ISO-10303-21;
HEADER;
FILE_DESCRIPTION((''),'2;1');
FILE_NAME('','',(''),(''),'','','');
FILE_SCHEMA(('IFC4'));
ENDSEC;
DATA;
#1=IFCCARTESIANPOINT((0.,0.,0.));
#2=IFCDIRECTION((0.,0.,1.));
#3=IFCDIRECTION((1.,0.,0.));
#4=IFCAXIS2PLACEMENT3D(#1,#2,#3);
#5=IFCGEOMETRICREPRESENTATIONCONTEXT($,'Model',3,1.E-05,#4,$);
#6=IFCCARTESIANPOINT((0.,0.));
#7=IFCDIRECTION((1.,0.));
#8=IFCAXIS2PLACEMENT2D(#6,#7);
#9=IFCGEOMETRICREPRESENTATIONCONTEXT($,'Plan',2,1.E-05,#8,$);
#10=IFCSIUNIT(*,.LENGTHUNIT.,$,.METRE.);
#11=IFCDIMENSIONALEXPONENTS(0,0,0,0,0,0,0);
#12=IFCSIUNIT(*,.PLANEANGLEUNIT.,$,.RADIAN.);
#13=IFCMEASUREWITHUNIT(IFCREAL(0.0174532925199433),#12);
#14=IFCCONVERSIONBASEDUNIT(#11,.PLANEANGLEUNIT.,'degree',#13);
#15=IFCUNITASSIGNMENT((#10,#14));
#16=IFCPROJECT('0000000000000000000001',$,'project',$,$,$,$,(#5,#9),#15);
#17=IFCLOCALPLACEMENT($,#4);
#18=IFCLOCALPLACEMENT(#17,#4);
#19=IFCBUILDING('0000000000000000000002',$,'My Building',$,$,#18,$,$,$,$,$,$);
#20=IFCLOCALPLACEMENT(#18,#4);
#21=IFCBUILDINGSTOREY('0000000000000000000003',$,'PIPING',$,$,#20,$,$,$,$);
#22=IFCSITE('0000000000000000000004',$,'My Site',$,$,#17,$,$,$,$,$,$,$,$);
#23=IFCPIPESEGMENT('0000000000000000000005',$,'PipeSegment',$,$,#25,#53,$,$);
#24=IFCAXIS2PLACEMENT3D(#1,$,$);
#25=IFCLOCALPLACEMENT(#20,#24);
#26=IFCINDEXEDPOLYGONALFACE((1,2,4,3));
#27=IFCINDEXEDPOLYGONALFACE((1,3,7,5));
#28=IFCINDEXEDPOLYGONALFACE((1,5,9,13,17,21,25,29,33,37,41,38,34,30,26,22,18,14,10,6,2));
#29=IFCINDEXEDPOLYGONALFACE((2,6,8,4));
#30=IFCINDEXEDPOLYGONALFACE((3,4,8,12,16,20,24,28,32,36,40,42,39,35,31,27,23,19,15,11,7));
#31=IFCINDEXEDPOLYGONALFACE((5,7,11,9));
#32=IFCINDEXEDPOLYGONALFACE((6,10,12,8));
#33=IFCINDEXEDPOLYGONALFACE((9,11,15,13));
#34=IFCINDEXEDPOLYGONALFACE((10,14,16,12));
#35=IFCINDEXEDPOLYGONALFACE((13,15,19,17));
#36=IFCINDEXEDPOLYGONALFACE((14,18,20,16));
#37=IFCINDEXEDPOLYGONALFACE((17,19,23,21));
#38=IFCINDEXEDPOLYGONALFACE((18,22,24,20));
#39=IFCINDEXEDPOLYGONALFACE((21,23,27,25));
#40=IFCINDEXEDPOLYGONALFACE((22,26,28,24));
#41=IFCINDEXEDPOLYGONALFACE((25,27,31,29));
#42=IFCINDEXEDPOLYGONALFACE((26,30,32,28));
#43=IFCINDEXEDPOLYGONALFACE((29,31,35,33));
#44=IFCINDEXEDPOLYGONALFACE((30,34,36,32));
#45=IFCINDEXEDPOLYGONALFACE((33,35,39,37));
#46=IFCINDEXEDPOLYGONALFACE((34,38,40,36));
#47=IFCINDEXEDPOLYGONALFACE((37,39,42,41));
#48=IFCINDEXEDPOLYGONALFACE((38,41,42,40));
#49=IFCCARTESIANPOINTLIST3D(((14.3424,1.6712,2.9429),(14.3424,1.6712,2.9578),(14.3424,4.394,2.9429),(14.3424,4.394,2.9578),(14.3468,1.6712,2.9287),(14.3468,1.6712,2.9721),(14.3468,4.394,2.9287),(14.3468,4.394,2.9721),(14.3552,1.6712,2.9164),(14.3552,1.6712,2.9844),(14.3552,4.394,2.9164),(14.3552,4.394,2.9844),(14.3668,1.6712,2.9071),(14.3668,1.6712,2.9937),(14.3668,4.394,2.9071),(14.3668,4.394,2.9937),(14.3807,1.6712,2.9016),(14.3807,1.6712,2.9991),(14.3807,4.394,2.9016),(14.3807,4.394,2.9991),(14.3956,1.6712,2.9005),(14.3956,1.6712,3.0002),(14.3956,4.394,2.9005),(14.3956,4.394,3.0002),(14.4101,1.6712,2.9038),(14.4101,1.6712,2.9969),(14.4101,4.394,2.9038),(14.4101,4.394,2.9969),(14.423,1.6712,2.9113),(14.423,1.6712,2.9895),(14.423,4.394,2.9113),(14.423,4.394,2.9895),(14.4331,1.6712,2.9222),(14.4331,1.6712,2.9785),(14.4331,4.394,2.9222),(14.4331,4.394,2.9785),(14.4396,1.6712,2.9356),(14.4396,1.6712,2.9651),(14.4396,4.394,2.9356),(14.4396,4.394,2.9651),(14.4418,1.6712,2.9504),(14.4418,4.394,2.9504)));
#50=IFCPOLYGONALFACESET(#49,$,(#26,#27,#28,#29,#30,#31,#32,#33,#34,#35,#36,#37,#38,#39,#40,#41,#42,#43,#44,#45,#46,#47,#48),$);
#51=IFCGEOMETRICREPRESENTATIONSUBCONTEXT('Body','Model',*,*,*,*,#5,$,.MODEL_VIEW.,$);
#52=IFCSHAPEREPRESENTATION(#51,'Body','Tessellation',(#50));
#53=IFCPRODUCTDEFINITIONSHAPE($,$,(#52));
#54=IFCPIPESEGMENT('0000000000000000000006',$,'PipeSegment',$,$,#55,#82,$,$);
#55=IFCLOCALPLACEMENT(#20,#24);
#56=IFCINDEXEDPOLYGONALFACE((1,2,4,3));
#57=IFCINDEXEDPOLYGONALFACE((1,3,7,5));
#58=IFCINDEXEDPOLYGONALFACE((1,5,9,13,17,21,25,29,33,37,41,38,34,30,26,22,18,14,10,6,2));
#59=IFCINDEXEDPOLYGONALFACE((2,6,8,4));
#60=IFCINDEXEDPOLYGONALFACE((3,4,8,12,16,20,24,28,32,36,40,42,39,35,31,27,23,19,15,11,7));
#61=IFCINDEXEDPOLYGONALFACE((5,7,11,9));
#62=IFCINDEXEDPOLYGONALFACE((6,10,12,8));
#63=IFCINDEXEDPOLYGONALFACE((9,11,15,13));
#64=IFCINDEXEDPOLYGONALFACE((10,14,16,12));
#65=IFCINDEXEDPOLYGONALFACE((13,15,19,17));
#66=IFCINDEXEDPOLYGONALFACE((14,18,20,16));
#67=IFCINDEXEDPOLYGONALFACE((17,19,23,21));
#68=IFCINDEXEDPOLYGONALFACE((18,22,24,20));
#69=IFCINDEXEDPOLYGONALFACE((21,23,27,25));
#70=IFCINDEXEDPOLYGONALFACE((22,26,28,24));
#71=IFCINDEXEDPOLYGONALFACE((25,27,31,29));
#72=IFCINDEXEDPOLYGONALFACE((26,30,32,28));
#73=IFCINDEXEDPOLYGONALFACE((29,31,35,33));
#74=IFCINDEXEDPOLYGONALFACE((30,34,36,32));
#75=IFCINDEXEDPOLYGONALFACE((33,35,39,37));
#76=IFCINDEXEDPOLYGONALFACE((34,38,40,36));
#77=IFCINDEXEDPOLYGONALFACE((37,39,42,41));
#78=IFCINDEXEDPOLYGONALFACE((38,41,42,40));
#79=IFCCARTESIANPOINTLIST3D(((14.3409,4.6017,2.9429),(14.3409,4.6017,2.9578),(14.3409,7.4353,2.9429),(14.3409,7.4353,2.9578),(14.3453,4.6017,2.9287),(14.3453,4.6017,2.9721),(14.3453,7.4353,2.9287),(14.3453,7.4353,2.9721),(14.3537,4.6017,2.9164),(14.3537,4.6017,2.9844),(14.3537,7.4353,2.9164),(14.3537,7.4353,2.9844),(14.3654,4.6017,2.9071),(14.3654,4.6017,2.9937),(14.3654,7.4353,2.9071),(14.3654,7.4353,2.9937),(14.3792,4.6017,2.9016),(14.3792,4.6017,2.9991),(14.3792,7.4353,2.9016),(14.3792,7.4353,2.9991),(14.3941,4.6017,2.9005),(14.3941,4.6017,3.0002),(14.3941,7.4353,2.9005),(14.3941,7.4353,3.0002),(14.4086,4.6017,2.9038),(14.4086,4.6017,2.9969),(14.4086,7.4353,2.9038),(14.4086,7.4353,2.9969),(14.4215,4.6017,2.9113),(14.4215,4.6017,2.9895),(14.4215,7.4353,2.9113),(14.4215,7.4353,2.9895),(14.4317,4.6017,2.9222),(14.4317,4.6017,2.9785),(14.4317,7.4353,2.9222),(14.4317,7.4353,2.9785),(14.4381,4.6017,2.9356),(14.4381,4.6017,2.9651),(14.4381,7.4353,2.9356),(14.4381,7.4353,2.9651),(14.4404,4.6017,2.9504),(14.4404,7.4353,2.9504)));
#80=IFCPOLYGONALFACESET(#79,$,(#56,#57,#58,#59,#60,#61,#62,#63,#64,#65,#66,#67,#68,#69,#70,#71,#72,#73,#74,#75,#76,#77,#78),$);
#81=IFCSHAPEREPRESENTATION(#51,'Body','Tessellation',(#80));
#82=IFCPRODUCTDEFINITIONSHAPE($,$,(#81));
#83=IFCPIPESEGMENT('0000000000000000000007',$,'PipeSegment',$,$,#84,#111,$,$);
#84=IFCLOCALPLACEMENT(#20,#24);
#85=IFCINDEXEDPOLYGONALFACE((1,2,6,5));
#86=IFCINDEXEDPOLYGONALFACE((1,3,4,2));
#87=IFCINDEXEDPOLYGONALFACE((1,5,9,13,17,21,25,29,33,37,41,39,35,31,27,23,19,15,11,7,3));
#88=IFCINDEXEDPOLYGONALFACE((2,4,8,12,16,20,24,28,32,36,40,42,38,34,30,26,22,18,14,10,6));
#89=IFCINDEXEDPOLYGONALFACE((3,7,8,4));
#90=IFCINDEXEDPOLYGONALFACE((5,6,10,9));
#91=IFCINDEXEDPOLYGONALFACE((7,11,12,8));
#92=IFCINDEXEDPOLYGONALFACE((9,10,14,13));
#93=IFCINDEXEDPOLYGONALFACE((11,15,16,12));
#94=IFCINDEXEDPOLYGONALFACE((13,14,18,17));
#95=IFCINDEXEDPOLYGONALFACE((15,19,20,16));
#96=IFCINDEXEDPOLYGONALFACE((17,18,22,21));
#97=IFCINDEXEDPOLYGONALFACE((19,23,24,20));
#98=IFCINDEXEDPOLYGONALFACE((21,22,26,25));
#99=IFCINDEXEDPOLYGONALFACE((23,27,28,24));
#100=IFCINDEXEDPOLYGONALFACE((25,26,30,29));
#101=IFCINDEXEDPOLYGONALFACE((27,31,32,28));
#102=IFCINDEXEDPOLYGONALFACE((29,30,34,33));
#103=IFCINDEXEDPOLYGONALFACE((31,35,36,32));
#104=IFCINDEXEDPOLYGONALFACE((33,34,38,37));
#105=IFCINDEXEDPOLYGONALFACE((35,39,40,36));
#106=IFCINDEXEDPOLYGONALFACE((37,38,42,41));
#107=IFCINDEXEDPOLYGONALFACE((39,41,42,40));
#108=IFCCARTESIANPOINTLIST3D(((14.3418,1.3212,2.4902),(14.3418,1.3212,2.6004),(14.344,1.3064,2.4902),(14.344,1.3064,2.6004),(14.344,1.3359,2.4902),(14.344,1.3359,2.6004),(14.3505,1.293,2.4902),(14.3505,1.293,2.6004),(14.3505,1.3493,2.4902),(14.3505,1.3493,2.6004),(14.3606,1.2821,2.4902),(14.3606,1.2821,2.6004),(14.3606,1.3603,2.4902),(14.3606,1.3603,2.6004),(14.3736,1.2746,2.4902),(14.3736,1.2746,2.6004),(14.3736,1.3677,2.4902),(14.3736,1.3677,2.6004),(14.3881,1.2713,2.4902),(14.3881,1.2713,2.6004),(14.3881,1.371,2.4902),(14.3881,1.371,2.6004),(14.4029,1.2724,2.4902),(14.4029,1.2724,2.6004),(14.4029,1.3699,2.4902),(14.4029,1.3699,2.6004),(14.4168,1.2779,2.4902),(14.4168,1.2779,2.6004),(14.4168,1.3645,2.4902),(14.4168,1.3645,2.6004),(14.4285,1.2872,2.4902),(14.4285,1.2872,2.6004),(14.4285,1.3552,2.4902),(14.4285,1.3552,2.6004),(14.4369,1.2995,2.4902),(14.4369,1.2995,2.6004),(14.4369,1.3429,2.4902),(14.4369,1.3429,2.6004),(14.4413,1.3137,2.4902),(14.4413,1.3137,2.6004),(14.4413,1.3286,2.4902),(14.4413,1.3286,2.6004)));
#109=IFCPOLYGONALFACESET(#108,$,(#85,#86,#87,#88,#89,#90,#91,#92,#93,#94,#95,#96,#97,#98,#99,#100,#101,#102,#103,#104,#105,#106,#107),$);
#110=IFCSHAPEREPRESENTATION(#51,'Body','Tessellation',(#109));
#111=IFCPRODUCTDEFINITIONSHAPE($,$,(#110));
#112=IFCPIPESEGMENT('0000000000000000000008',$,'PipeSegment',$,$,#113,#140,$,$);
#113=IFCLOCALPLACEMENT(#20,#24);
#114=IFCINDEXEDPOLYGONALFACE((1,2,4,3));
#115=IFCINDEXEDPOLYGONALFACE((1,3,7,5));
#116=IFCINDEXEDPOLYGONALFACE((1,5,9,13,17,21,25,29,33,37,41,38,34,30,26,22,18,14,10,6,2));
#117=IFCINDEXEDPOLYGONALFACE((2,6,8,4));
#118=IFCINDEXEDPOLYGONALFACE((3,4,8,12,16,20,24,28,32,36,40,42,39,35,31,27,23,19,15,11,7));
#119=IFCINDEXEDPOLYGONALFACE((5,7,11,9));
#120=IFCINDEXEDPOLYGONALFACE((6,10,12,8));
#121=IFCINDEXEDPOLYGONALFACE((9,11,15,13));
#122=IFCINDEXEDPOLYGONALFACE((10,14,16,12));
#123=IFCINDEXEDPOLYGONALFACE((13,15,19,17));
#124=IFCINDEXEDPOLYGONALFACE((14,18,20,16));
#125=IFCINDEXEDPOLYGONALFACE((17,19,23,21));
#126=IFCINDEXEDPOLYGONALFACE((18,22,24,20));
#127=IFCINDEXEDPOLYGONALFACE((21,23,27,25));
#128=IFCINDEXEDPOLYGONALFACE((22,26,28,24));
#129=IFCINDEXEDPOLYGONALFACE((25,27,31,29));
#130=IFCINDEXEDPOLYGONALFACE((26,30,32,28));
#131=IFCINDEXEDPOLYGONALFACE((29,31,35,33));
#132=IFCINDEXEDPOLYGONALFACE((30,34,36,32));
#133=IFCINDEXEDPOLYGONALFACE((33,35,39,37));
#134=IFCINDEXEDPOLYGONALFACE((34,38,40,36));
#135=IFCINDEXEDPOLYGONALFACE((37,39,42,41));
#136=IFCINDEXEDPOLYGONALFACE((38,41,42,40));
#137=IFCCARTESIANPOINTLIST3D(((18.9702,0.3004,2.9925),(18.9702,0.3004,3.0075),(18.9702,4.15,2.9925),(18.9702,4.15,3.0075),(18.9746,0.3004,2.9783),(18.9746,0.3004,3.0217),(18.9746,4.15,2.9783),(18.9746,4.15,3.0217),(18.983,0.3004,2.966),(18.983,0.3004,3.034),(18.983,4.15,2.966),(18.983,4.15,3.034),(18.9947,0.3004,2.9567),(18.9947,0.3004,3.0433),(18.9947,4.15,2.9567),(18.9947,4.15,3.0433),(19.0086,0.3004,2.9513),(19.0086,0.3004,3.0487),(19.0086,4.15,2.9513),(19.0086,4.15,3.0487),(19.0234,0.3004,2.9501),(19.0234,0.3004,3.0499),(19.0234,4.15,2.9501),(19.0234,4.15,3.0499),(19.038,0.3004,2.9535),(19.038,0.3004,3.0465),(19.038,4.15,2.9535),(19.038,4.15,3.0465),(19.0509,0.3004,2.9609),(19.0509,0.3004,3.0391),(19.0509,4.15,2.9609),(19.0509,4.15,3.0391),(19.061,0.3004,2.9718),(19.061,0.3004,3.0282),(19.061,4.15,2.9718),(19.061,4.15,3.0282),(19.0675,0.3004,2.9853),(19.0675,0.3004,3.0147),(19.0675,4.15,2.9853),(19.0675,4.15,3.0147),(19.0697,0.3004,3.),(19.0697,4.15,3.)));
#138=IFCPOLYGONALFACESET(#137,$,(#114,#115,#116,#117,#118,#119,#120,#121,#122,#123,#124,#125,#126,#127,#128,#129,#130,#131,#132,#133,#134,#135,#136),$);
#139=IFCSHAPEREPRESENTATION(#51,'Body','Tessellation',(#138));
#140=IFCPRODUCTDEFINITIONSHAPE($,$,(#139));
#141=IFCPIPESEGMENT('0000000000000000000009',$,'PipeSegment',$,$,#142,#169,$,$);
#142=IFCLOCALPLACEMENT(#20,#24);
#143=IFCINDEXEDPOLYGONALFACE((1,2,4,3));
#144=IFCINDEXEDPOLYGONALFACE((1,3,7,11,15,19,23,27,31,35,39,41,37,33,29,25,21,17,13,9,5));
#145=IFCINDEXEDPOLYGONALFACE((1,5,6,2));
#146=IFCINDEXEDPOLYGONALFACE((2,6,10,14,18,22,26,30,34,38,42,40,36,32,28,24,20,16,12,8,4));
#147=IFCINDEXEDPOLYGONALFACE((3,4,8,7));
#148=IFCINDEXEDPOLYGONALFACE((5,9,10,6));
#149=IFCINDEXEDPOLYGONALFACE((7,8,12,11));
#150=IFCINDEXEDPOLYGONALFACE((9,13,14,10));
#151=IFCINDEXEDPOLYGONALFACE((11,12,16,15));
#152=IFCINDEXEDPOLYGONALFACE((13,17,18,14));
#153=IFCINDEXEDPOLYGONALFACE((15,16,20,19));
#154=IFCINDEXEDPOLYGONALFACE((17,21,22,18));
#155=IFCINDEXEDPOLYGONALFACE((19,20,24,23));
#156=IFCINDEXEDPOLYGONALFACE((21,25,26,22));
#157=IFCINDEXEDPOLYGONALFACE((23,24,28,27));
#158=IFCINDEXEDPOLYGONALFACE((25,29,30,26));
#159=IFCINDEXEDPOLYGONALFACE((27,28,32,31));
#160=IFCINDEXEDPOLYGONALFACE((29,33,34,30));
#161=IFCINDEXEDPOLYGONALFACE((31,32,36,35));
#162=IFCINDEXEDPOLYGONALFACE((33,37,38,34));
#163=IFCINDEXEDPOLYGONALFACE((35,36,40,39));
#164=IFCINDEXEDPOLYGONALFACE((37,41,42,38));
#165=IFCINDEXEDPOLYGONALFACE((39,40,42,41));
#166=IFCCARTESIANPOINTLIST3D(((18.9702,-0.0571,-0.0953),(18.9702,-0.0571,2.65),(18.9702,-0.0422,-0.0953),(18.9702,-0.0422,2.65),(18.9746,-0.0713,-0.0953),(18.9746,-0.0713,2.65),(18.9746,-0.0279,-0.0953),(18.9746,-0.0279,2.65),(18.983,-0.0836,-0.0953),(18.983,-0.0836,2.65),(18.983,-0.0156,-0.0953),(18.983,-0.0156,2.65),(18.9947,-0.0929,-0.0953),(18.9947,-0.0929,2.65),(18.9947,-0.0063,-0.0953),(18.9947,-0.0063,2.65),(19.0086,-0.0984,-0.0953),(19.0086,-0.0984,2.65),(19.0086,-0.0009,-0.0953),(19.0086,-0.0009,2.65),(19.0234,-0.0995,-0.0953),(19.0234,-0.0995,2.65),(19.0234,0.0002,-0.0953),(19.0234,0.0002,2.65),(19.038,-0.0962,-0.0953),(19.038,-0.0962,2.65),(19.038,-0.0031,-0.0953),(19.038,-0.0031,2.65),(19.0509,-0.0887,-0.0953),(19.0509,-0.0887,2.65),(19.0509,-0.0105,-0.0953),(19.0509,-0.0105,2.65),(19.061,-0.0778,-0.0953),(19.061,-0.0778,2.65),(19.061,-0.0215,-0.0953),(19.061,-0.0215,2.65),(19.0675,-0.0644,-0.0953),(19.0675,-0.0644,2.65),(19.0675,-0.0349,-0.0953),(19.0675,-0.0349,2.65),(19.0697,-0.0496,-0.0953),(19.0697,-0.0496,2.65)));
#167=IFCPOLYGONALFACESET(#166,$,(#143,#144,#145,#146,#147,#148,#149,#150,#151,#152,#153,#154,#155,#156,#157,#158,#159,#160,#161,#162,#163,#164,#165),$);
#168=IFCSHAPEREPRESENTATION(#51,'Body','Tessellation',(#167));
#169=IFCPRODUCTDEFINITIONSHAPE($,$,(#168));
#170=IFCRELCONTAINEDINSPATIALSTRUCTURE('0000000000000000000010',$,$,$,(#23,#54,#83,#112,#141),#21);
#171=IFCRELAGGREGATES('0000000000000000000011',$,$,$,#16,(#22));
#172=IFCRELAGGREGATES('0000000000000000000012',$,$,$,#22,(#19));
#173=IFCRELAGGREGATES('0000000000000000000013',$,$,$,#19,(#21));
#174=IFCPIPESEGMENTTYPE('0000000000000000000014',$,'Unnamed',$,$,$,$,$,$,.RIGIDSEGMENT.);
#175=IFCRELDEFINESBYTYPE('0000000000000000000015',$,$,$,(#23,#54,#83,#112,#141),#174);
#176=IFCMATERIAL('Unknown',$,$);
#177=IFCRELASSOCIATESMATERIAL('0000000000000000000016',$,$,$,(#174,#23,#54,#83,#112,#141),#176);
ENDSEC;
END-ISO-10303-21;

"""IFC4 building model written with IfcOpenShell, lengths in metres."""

from ifc_helpers import new_model, entity, si_unit, converted_unit, frame, origin_with_axes, origin_2d_with_axis, place, context, subcontext, project, spatial, circle, extrude, material, material_profile, profile_set, profile_usage, type_object, element, save


model = new_model("IFC4")

# Units and contexts
model_context = context("Model", 3, precision=1e-05, world=origin_with_axes())
plan_context = context("Plan", 2, precision=1e-05, world=origin_2d_with_axis())
body_context = subcontext(model_context, "Body", "Model", "MODEL_VIEW")
ifc_project = project(units=[si_unit("LENGTHUNIT", "METRE"), converted_unit("PLANEANGLEUNIT", "degree", entity("IfcReal", 0.0174532925199433), si_unit("PLANEANGLEUNIT", "RADIAN"), dimensions=[0, 0, 0, 0, 0, 0, 0])], contexts=[model_context, plan_context])

# Site, building, storey
site_placement = place(None, origin_with_axes())
site = spatial("IfcSite", under=ifc_project, at=site_placement, Name="My Site")
building_placement = place(site_placement, origin_with_axes())
building = spatial("IfcBuilding", under=site, at=building_placement, Name="My Building")
storey_placement = place(building_placement, origin_with_axes())
storey = spatial("IfcBuildingStorey", under=building, at=storey_placement, Name="PIPING")

# Pipe segments
ifc_material = material(Name="Unknown")
ifc_material_profile_1 = material_profile(ifc_material, circle(Radius=0.05))
ifc_profile_set_1 = profile_set([ifc_material_profile_1])
pipe_segment_type = type_object("IfcPipeSegmentType", Name="Unnamed", PredefinedType="RIGIDSEGMENT", material=ifc_profile_set_1)
ifc_profile_usage_1 = profile_usage(ifc_profile_set_1, cardinal=5)
pipe_segment_1_placement = place(storey_placement, frame((14.3918, 1.6712, 2.9504), z_axis=(0.0, 1.0, 0.0), x_axis=(1.0, 0.0, 0.0)))
element("IfcPipeSegment", 1, at=pipe_segment_1_placement, inside=storey, type_object=pipe_segment_type, material=ifc_profile_usage_1, Name="PipeSegment", context=body_context, shape_type="SweptSolid", body=[
    extrude(circle(Radius=0.05), origin_with_axes(), (0.0, 0.0, 1.0), 2.7228),
])
ifc_profile_usage_2 = profile_usage(ifc_profile_set_1, cardinal=5)
pipe_segment_2_placement = place(storey_placement, frame((14.3904, 4.6017, 2.9504), z_axis=(0.0, 1.0, 0.0), x_axis=(1.0, 0.0, 0.0)))
element("IfcPipeSegment", 2, at=pipe_segment_2_placement, inside=storey, type_object=pipe_segment_type, material=ifc_profile_usage_2, Name="PipeSegment", context=body_context, shape_type="SweptSolid", body=[
    extrude(circle(Radius=0.05), origin_with_axes(), (0.0, 0.0, 1.0), 2.8337),
])
ifc_profile_usage_3 = profile_usage(ifc_profile_set_1, cardinal=5)
pipe_segment_3_placement = place(storey_placement, frame((14.3918, 1.3212, 2.6004), z_axis=(0.0, 0.0, -1.0), x_axis=(-1.0, 0.0, 0.0)))
element("IfcPipeSegment", 3, at=pipe_segment_3_placement, inside=storey, type_object=pipe_segment_type, material=ifc_profile_usage_3, Name="PipeSegment", context=body_context, shape_type="SweptSolid", body=[
    extrude(circle(Radius=0.05), origin_with_axes(), (0.0, 0.0, 1.0), 0.1102),
])
ifc_profile_usage_4 = profile_usage(ifc_profile_set_1, cardinal=5)
pipe_segment_4_placement = place(storey_placement, frame((19.0197, 4.15, 3.0), z_axis=(0.0, -1.0, 0.0), x_axis=(1.0, 0.0, 0.0)))
element("IfcPipeSegment", 4, at=pipe_segment_4_placement, inside=storey, type_object=pipe_segment_type, material=ifc_profile_usage_4, Name="PipeSegment", context=body_context, shape_type="SweptSolid", body=[
    extrude(circle(Radius=0.05), origin_with_axes(), (0.0, 0.0, 1.0), 3.8496),
])
ifc_profile_usage_5 = profile_usage(ifc_profile_set_1, cardinal=5)
pipe_segment_5_placement = place(storey_placement, frame((19.0197, -0.0496, 2.65), z_axis=(0.0, 0.0, -1.0), x_axis=(1.0, 0.0, 0.0)))
element("IfcPipeSegment", 5, at=pipe_segment_5_placement, inside=storey, type_object=pipe_segment_type, material=ifc_profile_usage_5, Name="PipeSegment", context=body_context, shape_type="SweptSolid", body=[
    extrude(circle(Radius=0.05), origin_with_axes(), (0.0, 0.0, 1.0), 2.7453),
])

save(model, "model.ifc")
